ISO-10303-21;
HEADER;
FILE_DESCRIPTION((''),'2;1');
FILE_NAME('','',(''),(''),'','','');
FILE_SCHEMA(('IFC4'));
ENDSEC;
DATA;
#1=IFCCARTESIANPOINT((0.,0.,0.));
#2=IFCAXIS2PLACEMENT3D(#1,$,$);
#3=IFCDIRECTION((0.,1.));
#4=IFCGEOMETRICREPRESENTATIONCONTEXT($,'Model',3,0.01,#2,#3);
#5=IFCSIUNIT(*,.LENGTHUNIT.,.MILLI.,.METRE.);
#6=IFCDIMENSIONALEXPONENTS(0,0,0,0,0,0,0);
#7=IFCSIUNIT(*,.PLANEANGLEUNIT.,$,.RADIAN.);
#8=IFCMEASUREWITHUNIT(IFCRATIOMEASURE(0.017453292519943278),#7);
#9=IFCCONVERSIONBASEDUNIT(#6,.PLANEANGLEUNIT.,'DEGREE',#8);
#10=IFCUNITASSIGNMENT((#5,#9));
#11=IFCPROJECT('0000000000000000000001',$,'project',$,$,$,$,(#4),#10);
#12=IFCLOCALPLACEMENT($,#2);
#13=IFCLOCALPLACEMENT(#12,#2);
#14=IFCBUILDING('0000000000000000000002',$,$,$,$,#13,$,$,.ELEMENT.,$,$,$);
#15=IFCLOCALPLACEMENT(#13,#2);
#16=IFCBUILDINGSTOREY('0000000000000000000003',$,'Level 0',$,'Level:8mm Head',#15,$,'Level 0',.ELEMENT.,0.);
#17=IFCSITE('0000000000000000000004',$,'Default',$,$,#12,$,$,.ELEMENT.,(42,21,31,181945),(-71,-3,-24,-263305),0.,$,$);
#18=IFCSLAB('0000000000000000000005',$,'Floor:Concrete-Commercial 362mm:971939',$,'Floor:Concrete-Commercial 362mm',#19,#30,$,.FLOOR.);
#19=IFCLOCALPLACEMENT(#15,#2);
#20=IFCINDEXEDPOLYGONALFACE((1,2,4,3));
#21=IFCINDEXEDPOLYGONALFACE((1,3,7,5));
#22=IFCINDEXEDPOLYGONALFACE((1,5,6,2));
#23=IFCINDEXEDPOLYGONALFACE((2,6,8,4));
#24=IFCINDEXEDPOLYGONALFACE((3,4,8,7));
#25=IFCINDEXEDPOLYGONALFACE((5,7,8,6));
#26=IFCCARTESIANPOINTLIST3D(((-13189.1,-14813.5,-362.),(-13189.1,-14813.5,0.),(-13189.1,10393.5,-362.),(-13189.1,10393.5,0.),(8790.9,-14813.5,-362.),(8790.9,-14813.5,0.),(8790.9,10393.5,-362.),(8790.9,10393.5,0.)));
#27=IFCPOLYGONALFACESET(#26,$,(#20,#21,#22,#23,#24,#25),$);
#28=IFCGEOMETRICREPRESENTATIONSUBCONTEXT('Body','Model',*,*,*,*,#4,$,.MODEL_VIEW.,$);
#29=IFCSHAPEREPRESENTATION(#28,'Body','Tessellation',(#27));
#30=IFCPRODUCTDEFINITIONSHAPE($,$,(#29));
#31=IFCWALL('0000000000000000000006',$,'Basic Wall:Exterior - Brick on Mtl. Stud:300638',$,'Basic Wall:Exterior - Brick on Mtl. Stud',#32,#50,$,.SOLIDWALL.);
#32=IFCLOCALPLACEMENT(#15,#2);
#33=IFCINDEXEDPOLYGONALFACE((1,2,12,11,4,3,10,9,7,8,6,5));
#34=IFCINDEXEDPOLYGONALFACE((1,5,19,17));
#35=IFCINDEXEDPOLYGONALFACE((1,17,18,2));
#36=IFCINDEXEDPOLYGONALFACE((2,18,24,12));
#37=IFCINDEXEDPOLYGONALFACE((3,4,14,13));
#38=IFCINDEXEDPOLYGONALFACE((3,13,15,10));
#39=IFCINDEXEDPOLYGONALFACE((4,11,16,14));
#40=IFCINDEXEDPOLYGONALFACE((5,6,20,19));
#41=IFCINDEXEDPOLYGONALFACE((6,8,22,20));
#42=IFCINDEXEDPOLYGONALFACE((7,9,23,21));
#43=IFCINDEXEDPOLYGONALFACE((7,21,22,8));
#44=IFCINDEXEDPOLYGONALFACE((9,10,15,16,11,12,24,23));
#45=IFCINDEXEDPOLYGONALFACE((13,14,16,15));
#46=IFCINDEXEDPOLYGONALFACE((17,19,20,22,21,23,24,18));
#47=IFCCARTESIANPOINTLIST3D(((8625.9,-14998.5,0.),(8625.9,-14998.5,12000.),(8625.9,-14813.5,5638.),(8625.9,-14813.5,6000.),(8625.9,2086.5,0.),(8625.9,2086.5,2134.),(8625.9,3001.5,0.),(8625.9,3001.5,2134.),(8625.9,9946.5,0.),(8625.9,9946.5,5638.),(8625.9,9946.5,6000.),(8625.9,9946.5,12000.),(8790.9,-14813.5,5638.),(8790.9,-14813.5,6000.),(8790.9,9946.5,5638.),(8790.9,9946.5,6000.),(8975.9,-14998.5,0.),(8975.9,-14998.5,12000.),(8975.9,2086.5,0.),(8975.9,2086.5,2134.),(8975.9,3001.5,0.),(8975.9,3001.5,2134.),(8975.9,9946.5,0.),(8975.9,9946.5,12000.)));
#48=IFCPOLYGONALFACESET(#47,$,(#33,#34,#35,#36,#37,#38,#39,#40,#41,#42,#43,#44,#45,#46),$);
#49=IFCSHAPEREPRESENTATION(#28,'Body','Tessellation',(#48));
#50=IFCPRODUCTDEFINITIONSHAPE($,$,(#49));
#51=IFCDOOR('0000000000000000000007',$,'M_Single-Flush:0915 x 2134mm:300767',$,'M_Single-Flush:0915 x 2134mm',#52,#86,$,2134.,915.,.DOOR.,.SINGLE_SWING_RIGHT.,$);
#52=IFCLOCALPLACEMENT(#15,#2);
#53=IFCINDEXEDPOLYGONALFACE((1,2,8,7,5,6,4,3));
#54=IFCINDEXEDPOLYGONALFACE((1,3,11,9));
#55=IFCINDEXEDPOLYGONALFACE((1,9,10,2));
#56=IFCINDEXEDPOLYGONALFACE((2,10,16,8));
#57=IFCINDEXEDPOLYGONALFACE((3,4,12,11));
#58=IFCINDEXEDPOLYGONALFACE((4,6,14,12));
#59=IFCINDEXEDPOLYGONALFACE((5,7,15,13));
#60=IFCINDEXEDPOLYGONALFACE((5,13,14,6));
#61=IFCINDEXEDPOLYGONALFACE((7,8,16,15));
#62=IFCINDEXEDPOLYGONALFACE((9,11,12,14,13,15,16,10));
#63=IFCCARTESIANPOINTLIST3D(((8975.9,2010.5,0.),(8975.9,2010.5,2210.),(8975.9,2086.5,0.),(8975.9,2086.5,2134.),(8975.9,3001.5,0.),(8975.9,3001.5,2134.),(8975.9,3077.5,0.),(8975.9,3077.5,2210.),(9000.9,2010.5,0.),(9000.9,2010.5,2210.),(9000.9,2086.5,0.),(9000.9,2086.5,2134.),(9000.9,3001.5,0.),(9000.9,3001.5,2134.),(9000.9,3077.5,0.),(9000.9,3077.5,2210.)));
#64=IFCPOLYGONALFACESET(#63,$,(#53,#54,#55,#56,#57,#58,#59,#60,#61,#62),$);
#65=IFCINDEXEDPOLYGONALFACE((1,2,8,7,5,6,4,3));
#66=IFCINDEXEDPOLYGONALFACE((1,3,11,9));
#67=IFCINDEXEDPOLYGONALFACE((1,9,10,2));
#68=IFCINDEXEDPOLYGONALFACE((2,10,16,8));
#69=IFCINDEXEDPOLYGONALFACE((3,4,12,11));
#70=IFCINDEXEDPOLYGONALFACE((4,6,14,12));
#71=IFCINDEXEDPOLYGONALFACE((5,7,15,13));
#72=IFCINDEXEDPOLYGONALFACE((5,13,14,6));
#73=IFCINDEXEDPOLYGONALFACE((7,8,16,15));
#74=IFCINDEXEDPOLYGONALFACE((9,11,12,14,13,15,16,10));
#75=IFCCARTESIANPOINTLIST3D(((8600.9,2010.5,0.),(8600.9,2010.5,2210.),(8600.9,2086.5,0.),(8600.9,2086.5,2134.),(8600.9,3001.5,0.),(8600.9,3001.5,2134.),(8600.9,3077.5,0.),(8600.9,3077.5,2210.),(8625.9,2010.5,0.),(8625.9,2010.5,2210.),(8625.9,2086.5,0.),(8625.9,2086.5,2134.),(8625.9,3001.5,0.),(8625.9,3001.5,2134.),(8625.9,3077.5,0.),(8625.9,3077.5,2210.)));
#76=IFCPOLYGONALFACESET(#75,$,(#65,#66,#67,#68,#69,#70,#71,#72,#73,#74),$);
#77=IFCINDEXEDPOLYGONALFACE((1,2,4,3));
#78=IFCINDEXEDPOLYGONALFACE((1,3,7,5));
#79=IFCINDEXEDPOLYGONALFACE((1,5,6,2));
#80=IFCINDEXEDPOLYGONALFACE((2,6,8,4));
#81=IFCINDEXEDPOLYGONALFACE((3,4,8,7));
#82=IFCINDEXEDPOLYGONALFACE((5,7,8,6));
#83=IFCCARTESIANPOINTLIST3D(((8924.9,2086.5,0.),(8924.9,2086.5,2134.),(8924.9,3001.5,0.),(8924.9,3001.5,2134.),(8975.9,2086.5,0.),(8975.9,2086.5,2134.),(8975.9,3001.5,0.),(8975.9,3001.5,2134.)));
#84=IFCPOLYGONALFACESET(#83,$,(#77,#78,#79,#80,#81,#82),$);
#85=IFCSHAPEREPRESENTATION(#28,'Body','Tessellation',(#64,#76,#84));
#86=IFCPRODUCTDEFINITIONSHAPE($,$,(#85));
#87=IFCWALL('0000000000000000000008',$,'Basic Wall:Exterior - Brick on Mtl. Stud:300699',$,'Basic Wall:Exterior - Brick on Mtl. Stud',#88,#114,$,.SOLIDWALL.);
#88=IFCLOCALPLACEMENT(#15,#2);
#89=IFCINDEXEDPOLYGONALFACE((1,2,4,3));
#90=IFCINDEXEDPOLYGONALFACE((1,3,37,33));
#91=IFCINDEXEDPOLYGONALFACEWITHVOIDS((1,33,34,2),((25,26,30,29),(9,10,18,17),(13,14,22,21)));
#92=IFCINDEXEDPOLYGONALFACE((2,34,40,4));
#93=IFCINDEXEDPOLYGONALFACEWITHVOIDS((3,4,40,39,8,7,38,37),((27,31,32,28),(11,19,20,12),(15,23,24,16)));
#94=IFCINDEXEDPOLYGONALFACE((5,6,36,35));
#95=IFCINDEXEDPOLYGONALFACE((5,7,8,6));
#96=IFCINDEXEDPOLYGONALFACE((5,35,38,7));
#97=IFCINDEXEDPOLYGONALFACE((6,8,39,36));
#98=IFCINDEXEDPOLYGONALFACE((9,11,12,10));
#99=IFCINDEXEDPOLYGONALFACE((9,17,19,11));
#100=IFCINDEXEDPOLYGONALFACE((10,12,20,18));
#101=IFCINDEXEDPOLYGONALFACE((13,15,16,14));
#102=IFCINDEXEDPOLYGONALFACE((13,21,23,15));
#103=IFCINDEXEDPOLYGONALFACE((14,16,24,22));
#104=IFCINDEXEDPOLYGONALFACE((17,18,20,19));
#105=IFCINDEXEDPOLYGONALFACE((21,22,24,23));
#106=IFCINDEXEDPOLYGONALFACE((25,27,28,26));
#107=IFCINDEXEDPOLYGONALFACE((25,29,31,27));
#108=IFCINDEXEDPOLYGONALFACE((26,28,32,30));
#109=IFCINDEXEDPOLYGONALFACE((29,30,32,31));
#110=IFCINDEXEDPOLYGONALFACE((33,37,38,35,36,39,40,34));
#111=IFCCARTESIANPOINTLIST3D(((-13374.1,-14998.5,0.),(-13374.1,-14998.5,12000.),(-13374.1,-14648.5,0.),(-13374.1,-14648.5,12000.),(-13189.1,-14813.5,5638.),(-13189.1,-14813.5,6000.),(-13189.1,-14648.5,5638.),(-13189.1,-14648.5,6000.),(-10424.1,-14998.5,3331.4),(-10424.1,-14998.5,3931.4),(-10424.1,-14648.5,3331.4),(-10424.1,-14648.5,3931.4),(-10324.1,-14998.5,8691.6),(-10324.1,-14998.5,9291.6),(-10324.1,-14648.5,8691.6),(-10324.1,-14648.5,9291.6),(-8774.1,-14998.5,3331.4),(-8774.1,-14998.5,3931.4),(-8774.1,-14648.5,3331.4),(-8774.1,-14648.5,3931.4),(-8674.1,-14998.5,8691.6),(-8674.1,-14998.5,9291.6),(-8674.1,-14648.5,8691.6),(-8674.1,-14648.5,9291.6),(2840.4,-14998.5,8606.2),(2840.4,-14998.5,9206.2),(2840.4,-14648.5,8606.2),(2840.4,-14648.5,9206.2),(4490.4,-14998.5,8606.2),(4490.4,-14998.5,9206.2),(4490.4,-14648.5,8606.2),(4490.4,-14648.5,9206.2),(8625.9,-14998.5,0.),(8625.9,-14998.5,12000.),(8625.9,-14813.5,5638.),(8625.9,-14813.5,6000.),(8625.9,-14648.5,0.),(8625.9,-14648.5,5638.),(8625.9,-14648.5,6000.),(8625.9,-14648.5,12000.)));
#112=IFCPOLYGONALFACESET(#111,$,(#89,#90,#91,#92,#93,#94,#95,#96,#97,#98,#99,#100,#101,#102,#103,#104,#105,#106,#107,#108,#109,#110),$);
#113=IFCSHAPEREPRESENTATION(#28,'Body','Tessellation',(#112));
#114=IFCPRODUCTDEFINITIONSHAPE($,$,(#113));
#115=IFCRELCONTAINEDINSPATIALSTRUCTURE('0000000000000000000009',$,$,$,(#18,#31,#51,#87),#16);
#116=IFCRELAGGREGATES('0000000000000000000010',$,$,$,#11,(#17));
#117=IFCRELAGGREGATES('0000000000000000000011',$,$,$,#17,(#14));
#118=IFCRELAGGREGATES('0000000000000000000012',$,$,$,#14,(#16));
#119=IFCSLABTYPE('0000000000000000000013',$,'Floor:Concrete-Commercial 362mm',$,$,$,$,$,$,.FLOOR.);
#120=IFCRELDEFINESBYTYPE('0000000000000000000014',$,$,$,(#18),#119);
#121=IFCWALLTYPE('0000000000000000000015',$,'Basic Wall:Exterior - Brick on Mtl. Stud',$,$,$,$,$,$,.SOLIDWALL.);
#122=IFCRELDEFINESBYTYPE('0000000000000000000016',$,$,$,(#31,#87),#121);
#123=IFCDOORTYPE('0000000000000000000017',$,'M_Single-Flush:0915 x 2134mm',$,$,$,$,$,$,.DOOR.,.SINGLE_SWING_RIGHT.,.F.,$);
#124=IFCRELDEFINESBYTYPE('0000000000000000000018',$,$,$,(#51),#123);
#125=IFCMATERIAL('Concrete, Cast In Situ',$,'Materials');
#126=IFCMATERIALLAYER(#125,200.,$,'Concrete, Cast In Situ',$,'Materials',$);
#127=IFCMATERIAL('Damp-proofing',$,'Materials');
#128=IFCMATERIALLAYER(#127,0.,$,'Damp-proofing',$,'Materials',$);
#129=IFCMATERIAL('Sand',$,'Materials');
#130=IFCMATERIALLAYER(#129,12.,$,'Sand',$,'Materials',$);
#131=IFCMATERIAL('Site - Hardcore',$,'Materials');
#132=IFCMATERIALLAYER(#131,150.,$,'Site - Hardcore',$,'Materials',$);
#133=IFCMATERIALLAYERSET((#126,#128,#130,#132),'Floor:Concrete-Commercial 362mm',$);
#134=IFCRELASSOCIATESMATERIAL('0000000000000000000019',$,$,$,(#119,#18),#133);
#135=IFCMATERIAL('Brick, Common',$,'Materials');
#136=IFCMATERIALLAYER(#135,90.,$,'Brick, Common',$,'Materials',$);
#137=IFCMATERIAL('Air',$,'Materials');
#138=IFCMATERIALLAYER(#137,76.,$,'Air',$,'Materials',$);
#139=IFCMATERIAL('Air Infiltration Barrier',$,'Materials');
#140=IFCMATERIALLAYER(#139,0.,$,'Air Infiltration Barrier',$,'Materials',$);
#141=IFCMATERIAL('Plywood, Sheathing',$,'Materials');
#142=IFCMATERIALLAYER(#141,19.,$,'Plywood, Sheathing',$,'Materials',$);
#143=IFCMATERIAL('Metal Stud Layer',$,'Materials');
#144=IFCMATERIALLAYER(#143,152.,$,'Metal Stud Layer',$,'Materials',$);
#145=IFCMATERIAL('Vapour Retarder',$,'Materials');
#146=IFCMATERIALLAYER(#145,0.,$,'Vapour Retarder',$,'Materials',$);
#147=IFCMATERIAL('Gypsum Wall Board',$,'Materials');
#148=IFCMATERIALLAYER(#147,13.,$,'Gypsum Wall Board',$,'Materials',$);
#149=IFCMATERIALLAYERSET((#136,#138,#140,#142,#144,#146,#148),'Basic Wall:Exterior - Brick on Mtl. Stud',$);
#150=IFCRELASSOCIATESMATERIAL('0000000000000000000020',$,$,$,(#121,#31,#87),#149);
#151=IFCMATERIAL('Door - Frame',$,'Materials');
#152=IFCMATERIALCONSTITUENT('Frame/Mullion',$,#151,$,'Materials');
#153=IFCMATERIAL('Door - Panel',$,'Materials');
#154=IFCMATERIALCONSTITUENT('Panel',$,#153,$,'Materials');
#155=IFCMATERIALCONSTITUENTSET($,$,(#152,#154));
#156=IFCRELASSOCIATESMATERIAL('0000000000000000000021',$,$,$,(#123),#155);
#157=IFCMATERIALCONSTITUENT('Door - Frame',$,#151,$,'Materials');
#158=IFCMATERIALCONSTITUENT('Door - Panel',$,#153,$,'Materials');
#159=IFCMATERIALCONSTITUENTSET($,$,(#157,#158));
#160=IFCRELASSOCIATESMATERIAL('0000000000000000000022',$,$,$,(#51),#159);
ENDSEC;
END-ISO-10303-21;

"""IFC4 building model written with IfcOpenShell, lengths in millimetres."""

from ifc_helpers import new_model, entity, si_unit, converted_unit, direction, frame, frame_2d, origin, place, context, subcontext, project, spatial, polyline, rectangle, outline, extrude, source, transform, mapped, material, layer, layer_set, layer_usage, constituent, constituent_set, type_object, type_shapes, element, fill, save


model = new_model("IFC4")

# Units and contexts
model_context = context("Model", 3, precision=0.01, world=origin(), true_north=direction((0.0, 1.0)))
body_context = subcontext(model_context, "Body", "Model", "MODEL_VIEW")
ifc_project = project(units=[si_unit("LENGTHUNIT", "METRE", prefix="MILLI"), converted_unit("PLANEANGLEUNIT", "DEGREE", entity("IfcRatioMeasure", 0.017453292519943278), si_unit("PLANEANGLEUNIT", "RADIAN"), dimensions=[0, 0, 0, 0, 0, 0, 0])], contexts=[model_context])

# Site, building, storey
site_placement = place(None, origin())
site = spatial("IfcSite", under=ifc_project, at=site_placement, Name="Default", CompositionType="ELEMENT", RefLatitude=(42, 21, 31, 181945), RefLongitude=(-71, -3, -24, -263305), RefElevation=0.0)
building_placement = place(site_placement, origin())
building = spatial("IfcBuilding", under=site, at=building_placement, CompositionType="ELEMENT")
storey_placement = place(building_placement, origin())
storey = spatial("IfcBuildingStorey", under=building, at=storey_placement, Name="Level 0", ObjectType="Level:8mm Head", LongName="Level 0", CompositionType="ELEMENT", Elevation=0.0)

# Slab
ifc_material_1 = material(Name="Concrete, Cast In Situ", Category="Materials")
ifc_layer_1 = layer(ifc_material_1, 200.0, Name="Concrete, Cast In Situ", Category="Materials")
ifc_material_2 = material(Name="Damp-proofing", Category="Materials")
ifc_layer_2 = layer(ifc_material_2, 0.0, Name="Damp-proofing", Category="Materials")
ifc_material_3 = material(Name="Sand", Category="Materials")
ifc_layer_3 = layer(ifc_material_3, 12.0, Name="Sand", Category="Materials")
ifc_material_4 = material(Name="Site - Hardcore", Category="Materials")
ifc_layer_4 = layer(ifc_material_4, 150.0, Name="Site - Hardcore", Category="Materials")
ifc_layer_set_1 = layer_set([ifc_layer_1, ifc_layer_2, ifc_layer_3, ifc_layer_4], Name="Floor:Concrete-Commercial 362mm")
ifc_layer_usage_1 = layer_usage(ifc_layer_set_1, "AXIS3", "POSITIVE", 0.0)
slab_type = type_object("IfcSlabType", Name="Floor:Concrete-Commercial 362mm", PredefinedType="FLOOR", material=ifc_layer_set_1)
slab_placement = place(storey_placement, origin())
element("IfcSlab", 1, at=slab_placement, inside=storey, type_object=slab_type, material=ifc_layer_usage_1, Name="Floor:Concrete-Commercial 362mm:971939", ObjectType="Floor:Concrete-Commercial 362mm", PredefinedType="FLOOR", context=body_context, shape_type="SweptSolid", body=[
    extrude(rectangle(XDim=25207.0, YDim=21980.0, at=frame_2d((0.0, 0.0), x_axis=(1.0, 0.0))), frame((-2199.1, -2210.0, 0.0), z_axis=(0.0, 0.0, -1.0), x_axis=(0.0, 1.0, 0.0)), (0.0, 0.0, 1.0), 362.0),
])

# Wall, openings, door
ifc_material_5 = material(Name="Brick, Common", Category="Materials")
ifc_layer_5 = layer(ifc_material_5, 90.0, Name="Brick, Common", Category="Materials")
ifc_material_6 = material(Name="Air", Category="Materials")
ifc_layer_6 = layer(ifc_material_6, 76.0, Name="Air", Category="Materials")
ifc_material_7 = material(Name="Air Infiltration Barrier", Category="Materials")
ifc_layer_7 = layer(ifc_material_7, 0.0, Name="Air Infiltration Barrier", Category="Materials")
ifc_material_8 = material(Name="Plywood, Sheathing", Category="Materials")
ifc_layer_8 = layer(ifc_material_8, 19.0, Name="Plywood, Sheathing", Category="Materials")
ifc_material_9 = material(Name="Metal Stud Layer", Category="Materials")
ifc_layer_9 = layer(ifc_material_9, 152.0, Name="Metal Stud Layer", Category="Materials")
ifc_material_10 = material(Name="Vapour Retarder", Category="Materials")
ifc_layer_10 = layer(ifc_material_10, 0.0, Name="Vapour Retarder", Category="Materials")
ifc_material_11 = material(Name="Gypsum Wall Board", Category="Materials")
ifc_layer_11 = layer(ifc_material_11, 13.0, Name="Gypsum Wall Board", Category="Materials")
ifc_layer_set_2 = layer_set([ifc_layer_5, ifc_layer_6, ifc_layer_7, ifc_layer_8, ifc_layer_9, ifc_layer_10, ifc_layer_11], Name="Basic Wall:Exterior - Brick on Mtl. Stud")
ifc_layer_usage_2 = layer_usage(ifc_layer_set_2, "AXIS2", "NEGATIVE", 175.0)
wall_type_1 = type_object("IfcWallType", Name="Basic Wall:Exterior - Brick on Mtl. Stud", PredefinedType="SOLIDWALL", material=ifc_layer_set_2)
wall_1_placement = place(storey_placement, frame((8800.9, 9946.5, 0.0), z_axis=(0.0, 0.0, 1.0), x_axis=(0.0, -1.0, 0.0)))
wall_1 = element("IfcWall", 2, at=wall_1_placement, inside=storey, type_object=wall_type_1, material=ifc_layer_usage_2, Name="Basic Wall:Exterior - Brick on Mtl. Stud:300638", ObjectType="Basic Wall:Exterior - Brick on Mtl. Stud", PredefinedType="SOLIDWALL", context=body_context, shape_type="SweptSolid", body=[
    extrude(rectangle(XDim=24945.0, YDim=350.0, at=frame_2d((12472.5, 0.0), x_axis=(-1.0, 0.0))), origin(), (0.0, 0.0, 1.0), 12000.0),
])
opening_1_placement = place(storey_placement, frame((8800.9, 9946.5, 0.0), z_axis=(0.0, 0.0, 1.0), x_axis=(0.0, -1.0, 0.0)))
element("IfcOpeningElement", 3, at=opening_1_placement, cuts=wall_1, PredefinedType="OPENING", context=body_context, shape_type="SweptSolid", body=[
    extrude(rectangle(XDim=165.0, YDim=24760.0, at=frame_2d((16.5, 2443.0), x_axis=(1.0, 0.0))), frame((14823.0, -109.0, 5638.0), z_axis=(0.0, 0.0, 1.0), x_axis=(0.0, 1.0, 0.0)), (0.0, 0.0, 1.0), 362.0),
])
opening_2_placement = place(wall_1_placement, frame((6945.0, -175.0, 0.0)))
opening_2 = element("IfcOpeningElement", 4, at=opening_2_placement, cuts=wall_1, PredefinedType="OPENING", context=body_context, shape_type="SweptSolid", body=[
    extrude(rectangle(XDim=915.0, YDim=2134.0, at=frame_2d((1067.0, 457.5), x_axis=(0.0, 1.0))), frame((0.0, 0.0, 0.0), z_axis=(0.0, 1.0, 0.0), x_axis=(0.0, 0.0, 1.0)), (0.0, 0.0, 1.0), 350.0),
])
ifc_material_12 = material(Name="Door - Frame", Category="Materials")
ifc_constituent_1 = constituent(ifc_material_12, Name="Door - Frame", Category="Materials")
ifc_material_13 = material(Name="Door - Panel", Category="Materials")
ifc_constituent_2 = constituent(ifc_material_13, Name="Door - Panel", Category="Materials")
ifc_constituent_set_1 = constituent_set(constituents=[ifc_constituent_1, ifc_constituent_2])
ifc_constituent_3 = constituent(ifc_material_12, Name="Frame/Mullion", Category="Materials")
ifc_constituent_4 = constituent(ifc_material_13, Name="Panel", Category="Materials")
ifc_constituent_set_2 = constituent_set(constituents=[ifc_constituent_3, ifc_constituent_4])
door_type_1 = type_object("IfcDoorType", Name="M_Single-Flush:0915 x 2134mm", OperationType="SINGLE_SWING_RIGHT", ParameterTakesPrecedence=False, PredefinedType="DOOR", material=ifc_constituent_set_2)
shared_shape_1 = source(origin(), body_context, "Body", "SweptSolid", [
    extrude(outline(polyline([(-533.5, -1124.0), (533.5, -1124.0), (533.5, 1086.0), (457.5, 1086.0), (457.5, -1048.0), (-457.5, -1048.0), (-457.5, 1086.0), (-533.5, 1086.0), (-533.5, -1124.0)])), frame((457.5, 350.0, 1086.0), z_axis=(0.0, 1.0, 0.0), x_axis=(1.0, 0.0, 0.0)), (0.0, 0.0, 1.0), 25.0),
    extrude(outline(polyline([(-1124.0, -533.5), (1086.0, -533.5), (1086.0, -457.5), (-1048.0, -457.5), (-1048.0, 457.5), (1086.0, 457.5), (1086.0, 533.5), (-1124.0, 533.5), (-1124.0, -533.5)])), frame((457.5, -25.0, 1086.0), z_axis=(0.0, 1.0, 0.0), x_axis=(0.0, 0.0, -1.0)), (0.0, 0.0, 1.0), 25.0),
    extrude(rectangle(XDim=51.0, YDim=915.0, at=frame_2d((0.0, 0.0), x_axis=(1.0, 0.0))), frame((457.5, 324.5, 0.0), z_axis=(0.0, 0.0, 1.0), x_axis=(0.0, 1.0, 0.0)), (0.0, 0.0, 1.0), 2134.0),
])
type_shapes(door_type_1, [shared_shape_1])
door_1_placement = place(opening_2_placement, origin())
door_1 = element("IfcDoor", 5, at=door_1_placement, inside=storey, type_object=door_type_1, material=ifc_constituent_set_1, Name="M_Single-Flush:0915 x 2134mm:300767", ObjectType="M_Single-Flush:0915 x 2134mm", OperationType="SINGLE_SWING_RIGHT", OverallHeight=2134.0, OverallWidth=915.0, PredefinedType="DOOR", context=body_context, shape_type="MappedRepresentation", body=[
    mapped(shared_shape_1, transform((0.0, 0.0, 0.0), scale=1.0)),
])
fill(opening_2, door_1)

# Wall, openings
wall_2_placement = place(storey_placement, frame((8625.9, -14823.5, 0.0), z_axis=(0.0, 0.0, 1.0), x_axis=(-1.0, 0.0, 0.0)))
wall_2 = element("IfcWall", 6, at=wall_2_placement, inside=storey, type_object=wall_type_1, material=ifc_layer_usage_2, Name="Basic Wall:Exterior - Brick on Mtl. Stud:300699", ObjectType="Basic Wall:Exterior - Brick on Mtl. Stud", PredefinedType="SOLIDWALL", context=body_context, shape_type="SweptSolid", body=[
    extrude(rectangle(XDim=22000.0, YDim=350.0, at=frame_2d((11000.0, 0.0), x_axis=(-1.0, 0.0))), origin(), (0.0, 0.0, 1.0), 12000.0),
])
opening_3_placement = place(storey_placement, frame((8625.9, -14823.5, 0.0), z_axis=(0.0, 0.0, 1.0), x_axis=(-1.0, 0.0, 0.0)))
element("IfcOpeningElement", 7, at=opening_3_placement, cuts=wall_2, PredefinedType="OPENING", context=body_context, shape_type="SweptSolid", body=[
    extrude(rectangle(XDim=165.0, YDim=21815.0, at=frame_2d((35.4, 82.5), x_axis=(1.0, 0.0))), frame((10990.0, -127.9, 5638.0), z_axis=(0.0, 0.0, 1.0), x_axis=(0.0, 1.0, 0.0)), (0.0, 0.0, 1.0), 362.0),
])
opening_4_placement = place(wall_2_placement, frame((17300.0, -175.0, 8691.6)))
element("IfcOpeningElement", 8, at=opening_4_placement, cuts=wall_2, PredefinedType="OPENING", context=body_context, shape_type="SweptSolid", body=[
    extrude(rectangle(XDim=600.0, YDim=1650.0, at=frame_2d((300.0, 825.0), x_axis=(-1.0, 0.0))), frame((0.0, 0.0, 0.0), z_axis=(0.0, 1.0, 0.0), x_axis=(0.0, 0.0, 1.0)), (0.0, 0.0, 1.0), 350.0),
])
opening_5_placement = place(wall_2_placement, frame((4135.5, -175.0, 8606.2)))
element("IfcOpeningElement", 9, at=opening_5_placement, cuts=wall_2, PredefinedType="OPENING", context=body_context, shape_type="SweptSolid", body=[
    extrude(rectangle(XDim=600.0, YDim=1650.0, at=frame_2d((300.0, 825.0), x_axis=(-1.0, 0.0))), frame((0.0, 0.0, 0.0), z_axis=(0.0, 1.0, 0.0), x_axis=(0.0, 0.0, 1.0)), (0.0, 0.0, 1.0), 350.0),
])
opening_6_placement = place(wall_2_placement, frame((17400.0, -175.0, 3331.4)))
element("IfcOpeningElement", 10, at=opening_6_placement, cuts=wall_2, PredefinedType="OPENING", context=body_context, shape_type="SweptSolid", body=[
    extrude(rectangle(XDim=600.0, YDim=1650.0, at=frame_2d((300.0, 825.0), x_axis=(-1.0, 0.0))), frame((0.0, 0.0, 0.0), z_axis=(0.0, 1.0, 0.0), x_axis=(0.0, 0.0, 1.0)), (0.0, 0.0, 1.0), 350.0),
])

save(model, "model.ifc")
